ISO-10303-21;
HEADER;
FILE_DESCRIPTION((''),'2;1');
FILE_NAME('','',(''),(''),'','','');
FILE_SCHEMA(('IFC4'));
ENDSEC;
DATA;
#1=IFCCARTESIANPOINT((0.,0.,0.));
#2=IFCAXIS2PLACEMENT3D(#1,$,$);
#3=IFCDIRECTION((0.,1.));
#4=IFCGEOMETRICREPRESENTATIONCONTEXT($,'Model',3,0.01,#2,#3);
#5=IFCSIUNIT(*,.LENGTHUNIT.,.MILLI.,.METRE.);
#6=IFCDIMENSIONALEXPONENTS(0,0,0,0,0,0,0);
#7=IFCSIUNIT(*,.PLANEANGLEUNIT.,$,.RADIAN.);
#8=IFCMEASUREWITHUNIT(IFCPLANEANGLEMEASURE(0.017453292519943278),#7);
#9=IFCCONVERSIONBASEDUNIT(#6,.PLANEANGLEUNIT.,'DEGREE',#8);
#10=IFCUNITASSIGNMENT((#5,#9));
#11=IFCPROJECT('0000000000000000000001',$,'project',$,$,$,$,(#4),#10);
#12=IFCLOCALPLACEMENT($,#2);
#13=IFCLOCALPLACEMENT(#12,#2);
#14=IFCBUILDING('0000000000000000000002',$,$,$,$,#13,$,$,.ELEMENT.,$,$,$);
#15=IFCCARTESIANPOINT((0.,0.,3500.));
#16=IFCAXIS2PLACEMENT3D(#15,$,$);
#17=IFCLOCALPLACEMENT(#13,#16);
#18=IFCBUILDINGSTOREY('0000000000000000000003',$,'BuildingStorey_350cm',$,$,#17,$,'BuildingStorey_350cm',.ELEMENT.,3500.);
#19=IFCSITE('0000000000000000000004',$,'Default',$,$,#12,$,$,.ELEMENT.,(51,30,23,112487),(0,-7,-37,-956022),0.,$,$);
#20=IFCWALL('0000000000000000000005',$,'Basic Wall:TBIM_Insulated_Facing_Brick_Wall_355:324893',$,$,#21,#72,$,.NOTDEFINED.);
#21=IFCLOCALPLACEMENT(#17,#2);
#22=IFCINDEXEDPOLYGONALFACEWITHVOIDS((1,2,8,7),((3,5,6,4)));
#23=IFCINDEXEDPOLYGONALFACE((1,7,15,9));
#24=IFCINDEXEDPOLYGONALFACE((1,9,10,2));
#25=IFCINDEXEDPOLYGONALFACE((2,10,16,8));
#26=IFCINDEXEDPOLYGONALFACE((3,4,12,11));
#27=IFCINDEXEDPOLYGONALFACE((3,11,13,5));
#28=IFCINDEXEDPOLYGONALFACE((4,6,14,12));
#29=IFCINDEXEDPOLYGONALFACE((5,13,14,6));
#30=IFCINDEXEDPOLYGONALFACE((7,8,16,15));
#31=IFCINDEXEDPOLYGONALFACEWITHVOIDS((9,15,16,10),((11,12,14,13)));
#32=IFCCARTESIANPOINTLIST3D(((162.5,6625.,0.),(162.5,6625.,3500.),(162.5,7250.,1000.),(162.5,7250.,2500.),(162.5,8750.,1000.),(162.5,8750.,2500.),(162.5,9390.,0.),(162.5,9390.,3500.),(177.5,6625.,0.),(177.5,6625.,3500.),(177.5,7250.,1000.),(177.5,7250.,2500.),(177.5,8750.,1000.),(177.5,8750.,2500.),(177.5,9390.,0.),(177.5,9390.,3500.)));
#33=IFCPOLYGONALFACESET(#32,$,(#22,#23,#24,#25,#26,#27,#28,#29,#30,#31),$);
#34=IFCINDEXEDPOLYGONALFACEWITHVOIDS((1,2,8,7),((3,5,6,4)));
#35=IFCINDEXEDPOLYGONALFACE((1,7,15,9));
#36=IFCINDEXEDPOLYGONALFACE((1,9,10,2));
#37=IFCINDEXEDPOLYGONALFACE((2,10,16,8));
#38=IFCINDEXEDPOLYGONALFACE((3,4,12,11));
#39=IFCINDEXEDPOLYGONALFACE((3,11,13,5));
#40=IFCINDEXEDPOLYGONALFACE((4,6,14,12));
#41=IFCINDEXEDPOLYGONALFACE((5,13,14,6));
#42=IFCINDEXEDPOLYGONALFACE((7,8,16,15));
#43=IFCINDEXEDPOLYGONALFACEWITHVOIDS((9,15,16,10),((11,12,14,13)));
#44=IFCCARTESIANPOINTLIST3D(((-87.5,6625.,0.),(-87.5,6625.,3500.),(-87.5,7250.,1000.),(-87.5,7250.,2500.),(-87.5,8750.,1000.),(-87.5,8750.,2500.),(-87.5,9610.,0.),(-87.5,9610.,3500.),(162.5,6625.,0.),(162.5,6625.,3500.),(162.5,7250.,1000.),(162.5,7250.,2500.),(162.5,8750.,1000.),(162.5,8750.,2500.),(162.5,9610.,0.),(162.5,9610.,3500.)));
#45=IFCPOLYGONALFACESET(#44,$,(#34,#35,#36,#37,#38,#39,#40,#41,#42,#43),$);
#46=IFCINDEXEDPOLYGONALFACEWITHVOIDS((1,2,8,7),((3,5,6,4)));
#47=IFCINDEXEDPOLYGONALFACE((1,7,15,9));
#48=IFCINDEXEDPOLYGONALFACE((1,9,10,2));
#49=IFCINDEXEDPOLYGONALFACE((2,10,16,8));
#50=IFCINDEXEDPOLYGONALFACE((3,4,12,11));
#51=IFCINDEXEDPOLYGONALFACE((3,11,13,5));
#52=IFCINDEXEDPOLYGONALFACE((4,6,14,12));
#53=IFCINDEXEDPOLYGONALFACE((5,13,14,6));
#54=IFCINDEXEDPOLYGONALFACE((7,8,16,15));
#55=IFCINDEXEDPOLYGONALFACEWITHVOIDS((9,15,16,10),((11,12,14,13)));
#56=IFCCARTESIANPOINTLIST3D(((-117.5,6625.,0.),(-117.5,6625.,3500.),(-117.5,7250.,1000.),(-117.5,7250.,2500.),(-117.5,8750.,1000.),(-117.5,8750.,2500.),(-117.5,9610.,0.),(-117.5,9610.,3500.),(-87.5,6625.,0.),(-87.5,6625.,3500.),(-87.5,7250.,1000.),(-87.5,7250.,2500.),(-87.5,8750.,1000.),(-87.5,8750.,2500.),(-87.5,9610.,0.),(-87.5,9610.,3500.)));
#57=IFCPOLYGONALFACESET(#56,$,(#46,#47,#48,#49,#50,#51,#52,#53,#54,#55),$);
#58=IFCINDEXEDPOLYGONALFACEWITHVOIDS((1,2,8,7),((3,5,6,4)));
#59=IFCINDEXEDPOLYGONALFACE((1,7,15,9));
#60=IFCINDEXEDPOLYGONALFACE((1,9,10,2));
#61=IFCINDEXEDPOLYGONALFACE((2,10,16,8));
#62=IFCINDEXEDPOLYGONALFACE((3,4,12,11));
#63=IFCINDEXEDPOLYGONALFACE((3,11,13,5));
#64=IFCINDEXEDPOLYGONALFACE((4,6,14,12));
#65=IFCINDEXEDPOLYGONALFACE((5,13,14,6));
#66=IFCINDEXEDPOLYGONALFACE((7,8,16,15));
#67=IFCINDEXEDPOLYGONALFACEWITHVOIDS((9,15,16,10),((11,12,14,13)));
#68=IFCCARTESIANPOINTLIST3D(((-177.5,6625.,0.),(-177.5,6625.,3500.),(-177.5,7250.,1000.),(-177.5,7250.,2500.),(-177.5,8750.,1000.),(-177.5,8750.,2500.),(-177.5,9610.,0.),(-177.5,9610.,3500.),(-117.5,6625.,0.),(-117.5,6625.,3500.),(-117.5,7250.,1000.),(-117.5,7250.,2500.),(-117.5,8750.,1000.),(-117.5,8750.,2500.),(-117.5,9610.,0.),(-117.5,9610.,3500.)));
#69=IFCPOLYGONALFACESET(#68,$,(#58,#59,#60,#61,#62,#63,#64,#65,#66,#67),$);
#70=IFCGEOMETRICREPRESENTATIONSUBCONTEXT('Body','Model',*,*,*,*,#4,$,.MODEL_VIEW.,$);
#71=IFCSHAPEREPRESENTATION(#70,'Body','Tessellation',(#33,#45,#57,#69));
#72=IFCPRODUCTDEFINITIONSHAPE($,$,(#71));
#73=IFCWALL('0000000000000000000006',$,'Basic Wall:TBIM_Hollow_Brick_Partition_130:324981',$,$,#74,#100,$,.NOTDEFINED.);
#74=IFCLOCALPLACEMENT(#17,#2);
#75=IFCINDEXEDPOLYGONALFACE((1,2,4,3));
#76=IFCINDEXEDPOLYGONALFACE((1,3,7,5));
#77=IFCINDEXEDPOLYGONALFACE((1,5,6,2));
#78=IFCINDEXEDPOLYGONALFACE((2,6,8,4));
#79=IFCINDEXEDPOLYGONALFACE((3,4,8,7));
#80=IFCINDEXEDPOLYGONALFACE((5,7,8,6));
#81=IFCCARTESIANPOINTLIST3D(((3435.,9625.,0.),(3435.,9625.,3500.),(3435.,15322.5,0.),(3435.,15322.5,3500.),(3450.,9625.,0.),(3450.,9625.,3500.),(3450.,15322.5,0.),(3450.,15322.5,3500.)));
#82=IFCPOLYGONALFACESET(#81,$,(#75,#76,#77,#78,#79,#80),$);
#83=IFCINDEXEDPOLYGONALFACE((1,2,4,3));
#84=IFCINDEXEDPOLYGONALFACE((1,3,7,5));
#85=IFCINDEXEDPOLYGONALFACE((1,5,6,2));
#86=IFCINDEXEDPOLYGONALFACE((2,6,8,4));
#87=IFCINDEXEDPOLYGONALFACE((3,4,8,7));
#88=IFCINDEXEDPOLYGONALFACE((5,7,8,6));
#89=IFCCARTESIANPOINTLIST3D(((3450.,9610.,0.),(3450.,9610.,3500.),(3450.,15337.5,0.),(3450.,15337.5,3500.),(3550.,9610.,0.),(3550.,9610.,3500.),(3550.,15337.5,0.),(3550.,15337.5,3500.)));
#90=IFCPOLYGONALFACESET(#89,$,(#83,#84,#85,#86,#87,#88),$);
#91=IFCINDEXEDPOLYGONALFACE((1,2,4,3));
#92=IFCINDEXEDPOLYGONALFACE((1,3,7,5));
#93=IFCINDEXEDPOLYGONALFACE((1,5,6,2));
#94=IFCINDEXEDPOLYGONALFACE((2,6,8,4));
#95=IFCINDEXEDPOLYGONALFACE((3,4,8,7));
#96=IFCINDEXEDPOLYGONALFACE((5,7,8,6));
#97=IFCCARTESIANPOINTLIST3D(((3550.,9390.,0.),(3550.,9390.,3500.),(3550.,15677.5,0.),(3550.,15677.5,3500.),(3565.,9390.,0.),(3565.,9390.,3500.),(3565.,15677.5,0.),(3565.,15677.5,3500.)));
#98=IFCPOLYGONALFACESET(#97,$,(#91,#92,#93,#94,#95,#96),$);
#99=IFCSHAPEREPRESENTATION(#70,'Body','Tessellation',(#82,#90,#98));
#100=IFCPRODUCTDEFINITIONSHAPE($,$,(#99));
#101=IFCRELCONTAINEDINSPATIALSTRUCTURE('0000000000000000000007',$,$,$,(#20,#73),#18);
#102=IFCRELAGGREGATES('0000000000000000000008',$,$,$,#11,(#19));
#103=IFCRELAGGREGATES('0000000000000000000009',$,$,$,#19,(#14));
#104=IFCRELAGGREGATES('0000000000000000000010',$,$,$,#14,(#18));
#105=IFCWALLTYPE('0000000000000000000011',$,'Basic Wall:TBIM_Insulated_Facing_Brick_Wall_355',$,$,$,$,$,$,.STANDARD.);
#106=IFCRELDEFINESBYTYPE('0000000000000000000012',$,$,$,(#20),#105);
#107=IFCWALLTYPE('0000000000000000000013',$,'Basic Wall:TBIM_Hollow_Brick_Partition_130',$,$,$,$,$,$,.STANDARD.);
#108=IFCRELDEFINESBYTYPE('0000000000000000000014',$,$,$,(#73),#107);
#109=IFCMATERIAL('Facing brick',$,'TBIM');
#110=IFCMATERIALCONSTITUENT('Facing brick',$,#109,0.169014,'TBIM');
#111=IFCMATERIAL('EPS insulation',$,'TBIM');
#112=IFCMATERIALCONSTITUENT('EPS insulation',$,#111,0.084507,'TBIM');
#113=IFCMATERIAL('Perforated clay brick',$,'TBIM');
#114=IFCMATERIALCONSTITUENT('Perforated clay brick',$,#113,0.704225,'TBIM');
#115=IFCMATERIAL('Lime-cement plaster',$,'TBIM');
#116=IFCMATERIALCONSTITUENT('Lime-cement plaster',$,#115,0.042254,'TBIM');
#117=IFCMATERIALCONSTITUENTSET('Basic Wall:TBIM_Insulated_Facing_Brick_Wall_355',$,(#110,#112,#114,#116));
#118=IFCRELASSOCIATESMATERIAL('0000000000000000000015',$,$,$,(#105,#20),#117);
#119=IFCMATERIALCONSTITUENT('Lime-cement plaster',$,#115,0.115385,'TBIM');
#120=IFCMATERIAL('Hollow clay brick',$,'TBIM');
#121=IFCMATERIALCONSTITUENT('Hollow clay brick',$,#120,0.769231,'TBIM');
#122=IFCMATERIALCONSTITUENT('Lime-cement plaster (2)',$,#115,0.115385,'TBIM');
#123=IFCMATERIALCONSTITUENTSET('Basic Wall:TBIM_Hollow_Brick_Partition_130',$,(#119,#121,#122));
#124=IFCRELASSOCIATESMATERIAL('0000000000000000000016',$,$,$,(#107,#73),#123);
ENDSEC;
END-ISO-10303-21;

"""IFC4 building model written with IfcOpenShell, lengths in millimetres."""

from ifc_helpers import new_model, entity, si_unit, converted_unit, direction, frame, origin, place, context, subcontext, project, spatial, indexed_curve, outline, extrude, material, constituent, constituent_set, type_object, element, save


model = new_model("IFC4")

# Units and contexts
model_context = context("Model", 3, precision=0.01, world=origin(), true_north=direction((0.0, 1.0)))
body_context = subcontext(model_context, "Body", "Model", "MODEL_VIEW")
ifc_project = project(units=[si_unit("LENGTHUNIT", "METRE", prefix="MILLI"), converted_unit("PLANEANGLEUNIT", "DEGREE", entity("IfcPlaneAngleMeasure", 0.017453292519943278), si_unit("PLANEANGLEUNIT", "RADIAN"), dimensions=[0, 0, 0, 0, 0, 0, 0])], contexts=[model_context])

# Site, building, storey
site_placement = place(None, origin())
site = spatial("IfcSite", under=ifc_project, at=site_placement, Name="Default", CompositionType="ELEMENT", RefLatitude=(51, 30, 23, 112487), RefLongitude=(0, -7, -37, -956022), RefElevation=0.0)
building_placement = place(site_placement, origin())
building = spatial("IfcBuilding", under=site, at=building_placement, CompositionType="ELEMENT")
storey_placement = place(building_placement, frame((0.0, 0.0, 3500.0)))
storey = spatial("IfcBuildingStorey", under=building, at=storey_placement, Name="BuildingStorey_350cm", LongName="BuildingStorey_350cm", CompositionType="ELEMENT", Elevation=3500.0)

# Shared definitions
ifc_material_1 = material(Name="Lime-cement plaster", Category="TBIM")

# Wall, opening
ifc_material_2 = material(Name="Facing brick", Category="TBIM")
ifc_constituent_1 = constituent(ifc_material_2, Name="Facing brick", Category="TBIM", fraction=0.169014)
ifc_material_3 = material(Name="EPS insulation", Category="TBIM")
ifc_constituent_2 = constituent(ifc_material_3, Name="EPS insulation", Category="TBIM", fraction=0.084507)
ifc_material_4 = material(Name="Perforated clay brick", Category="TBIM")
ifc_constituent_3 = constituent(ifc_material_4, Name="Perforated clay brick", Category="TBIM", fraction=0.704225)
ifc_constituent_4 = constituent(ifc_material_1, Name="Lime-cement plaster", Category="TBIM", fraction=0.042254)
ifc_constituent_set_1 = constituent_set(constituents=[ifc_constituent_1, ifc_constituent_2, ifc_constituent_3, ifc_constituent_4], Name="Basic Wall:TBIM_Insulated_Facing_Brick_Wall_355")
wall_type_1 = type_object("IfcWallType", Name="Basic Wall:TBIM_Insulated_Facing_Brick_Wall_355", PredefinedType="STANDARD", material=ifc_constituent_set_1)
wall_1_placement = place(storey_placement, frame((0.0, 9625.0, 0.0), z_axis=(0.0, 0.0, 1.0), x_axis=(0.0, -1.0, 0.0)))
wall_1 = element("IfcWall", 1, at=wall_1_placement, inside=storey, type_object=wall_type_1, material=ifc_constituent_set_1, Name="Basic Wall:TBIM_Insulated_Facing_Brick_Wall_355:324893", PredefinedType="NOTDEFINED", context=body_context, shape_type="SweptSolid", body=[
    extrude(outline(indexed_curve([(-1750.0, -1382.5), (1750.0, -1382.5), (1750.0, 1382.5), (-1750.0, 1382.5), (-1750.0, -1382.5)], self_intersect=False), holes=[indexed_curve([(-750.0, -742.5), (-750.0, 757.5), (750.0, 757.5), (750.0, -742.5), (-750.0, -742.5)], self_intersect=False)]), frame((1617.5, 162.5, 1750.0), z_axis=(0.0, 1.0, 0.0), x_axis=(0.0, 0.0, 1.0)), (0.0, 0.0, 1.0), 15.0),
    extrude(outline(indexed_curve([(-1750.0, -1492.5), (1750.0, -1492.5), (1750.0, 1492.5), (-1750.0, 1492.5), (-1750.0, -1492.5)], self_intersect=False), holes=[indexed_curve([(-750.0, -632.5), (-750.0, 867.5), (750.0, 867.5), (750.0, -632.5), (-750.0, -632.5)], self_intersect=False)]), frame((1507.5, -87.5, 1750.0), z_axis=(0.0, 1.0, 0.0), x_axis=(0.0, 0.0, 1.0)), (0.0, 0.0, 1.0), 250.0),
    extrude(outline(indexed_curve([(-1750.0, -1492.5), (1750.0, -1492.5), (1750.0, 1492.5), (-1750.0, 1492.5), (-1750.0, -1492.5)], self_intersect=False), holes=[indexed_curve([(-750.0, -632.5), (-750.0, 867.5), (750.0, 867.5), (750.0, -632.5), (-750.0, -632.5)], self_intersect=False)]), frame((1507.5, -117.5, 1750.0), z_axis=(0.0, 1.0, 0.0), x_axis=(0.0, 0.0, 1.0)), (0.0, 0.0, 1.0), 30.0),
    extrude(outline(indexed_curve([(-1750.0, -1492.5), (1750.0, -1492.5), (1750.0, 1492.5), (-1750.0, 1492.5), (-1750.0, -1492.5)], self_intersect=False), holes=[indexed_curve([(750.0, -632.5), (-750.0, -632.5), (-750.0, 867.5), (750.0, 867.5), (750.0, -632.5)], self_intersect=False)]), frame((1507.5, -177.5, 1750.0), z_axis=(0.0, 1.0, 0.0), x_axis=(0.0, 0.0, 1.0)), (0.0, 0.0, 1.0), 60.0),
])
opening_1_placement = place(wall_1_placement, frame((875.0, -177.5, 1000.0)))
element("IfcOpeningElement", 2, at=opening_1_placement, cuts=wall_1, PredefinedType="OPENING", context=body_context, shape_type="SweptSolid", body=[
    extrude(outline(indexed_curve([(1500.0, 0.0), (1500.0, 1500.0), (0.0, 1500.0), (0.0, 0.0), (1500.0, 0.0)], self_intersect=False)), frame((0.0, 0.0, 0.0), z_axis=(0.0, 1.0, 0.0), x_axis=(0.0, 0.0, 1.0)), (0.0, 0.0, 1.0), 355.0),
])

# Wall
ifc_constituent_5 = constituent(ifc_material_1, Name="Lime-cement plaster", Category="TBIM", fraction=0.115385)
ifc_material_5 = material(Name="Hollow clay brick", Category="TBIM")
ifc_constituent_6 = constituent(ifc_material_5, Name="Hollow clay brick", Category="TBIM", fraction=0.769231)
ifc_constituent_7 = constituent(ifc_material_1, Name="Lime-cement plaster (2)", Category="TBIM", fraction=0.115385)
ifc_constituent_set_2 = constituent_set(constituents=[ifc_constituent_5, ifc_constituent_6, ifc_constituent_7], Name="Basic Wall:TBIM_Hollow_Brick_Partition_130")
wall_type_2 = type_object("IfcWallType", Name="Basic Wall:TBIM_Hollow_Brick_Partition_130", PredefinedType="STANDARD", material=ifc_constituent_set_2)
wall_2_placement = place(storey_placement, frame((3500.0, 9625.0, 0.0), z_axis=(0.0, 0.0, 1.0), x_axis=(0.0, 1.0, 0.0)))
element("IfcWall", 3, at=wall_2_placement, inside=storey, type_object=wall_type_2, material=ifc_constituent_set_2, Name="Basic Wall:TBIM_Hollow_Brick_Partition_130:324981", PredefinedType="NOTDEFINED", context=body_context, shape_type="SweptSolid", body=[
    extrude(outline(indexed_curve([(-7.5, -2848.8), (7.5, -2848.8), (7.5, 2848.8), (-7.5, 2848.8), (-7.5, -2848.8)], self_intersect=False)), frame((2848.8, 57.5, 0.0), z_axis=(0.0, 0.0, 1.0), x_axis=(0.0, -1.0, 0.0)), (0.0, 0.0, 1.0), 3500.0),
    extrude(outline(indexed_curve([(-2863.7, -50.0), (2863.8, -50.0), (2863.8, 50.0), (-2863.7, 50.0), (-2863.7, -50.0)], self_intersect=False)), frame((2848.8, 0.0, 0.0)), (0.0, 0.0, 1.0), 3500.0),
    extrude(outline(indexed_curve([(-7.5, -3143.8), (7.5, -3143.8), (7.5, 3143.7), (-7.5, 3143.7), (-7.5, -3143.8)], self_intersect=False)), frame((2908.7, -57.5, 0.0), z_axis=(0.0, 0.0, 1.0), x_axis=(0.0, 1.0, 0.0)), (0.0, 0.0, 1.0), 3500.0),
])

save(model, "model.ifc")
